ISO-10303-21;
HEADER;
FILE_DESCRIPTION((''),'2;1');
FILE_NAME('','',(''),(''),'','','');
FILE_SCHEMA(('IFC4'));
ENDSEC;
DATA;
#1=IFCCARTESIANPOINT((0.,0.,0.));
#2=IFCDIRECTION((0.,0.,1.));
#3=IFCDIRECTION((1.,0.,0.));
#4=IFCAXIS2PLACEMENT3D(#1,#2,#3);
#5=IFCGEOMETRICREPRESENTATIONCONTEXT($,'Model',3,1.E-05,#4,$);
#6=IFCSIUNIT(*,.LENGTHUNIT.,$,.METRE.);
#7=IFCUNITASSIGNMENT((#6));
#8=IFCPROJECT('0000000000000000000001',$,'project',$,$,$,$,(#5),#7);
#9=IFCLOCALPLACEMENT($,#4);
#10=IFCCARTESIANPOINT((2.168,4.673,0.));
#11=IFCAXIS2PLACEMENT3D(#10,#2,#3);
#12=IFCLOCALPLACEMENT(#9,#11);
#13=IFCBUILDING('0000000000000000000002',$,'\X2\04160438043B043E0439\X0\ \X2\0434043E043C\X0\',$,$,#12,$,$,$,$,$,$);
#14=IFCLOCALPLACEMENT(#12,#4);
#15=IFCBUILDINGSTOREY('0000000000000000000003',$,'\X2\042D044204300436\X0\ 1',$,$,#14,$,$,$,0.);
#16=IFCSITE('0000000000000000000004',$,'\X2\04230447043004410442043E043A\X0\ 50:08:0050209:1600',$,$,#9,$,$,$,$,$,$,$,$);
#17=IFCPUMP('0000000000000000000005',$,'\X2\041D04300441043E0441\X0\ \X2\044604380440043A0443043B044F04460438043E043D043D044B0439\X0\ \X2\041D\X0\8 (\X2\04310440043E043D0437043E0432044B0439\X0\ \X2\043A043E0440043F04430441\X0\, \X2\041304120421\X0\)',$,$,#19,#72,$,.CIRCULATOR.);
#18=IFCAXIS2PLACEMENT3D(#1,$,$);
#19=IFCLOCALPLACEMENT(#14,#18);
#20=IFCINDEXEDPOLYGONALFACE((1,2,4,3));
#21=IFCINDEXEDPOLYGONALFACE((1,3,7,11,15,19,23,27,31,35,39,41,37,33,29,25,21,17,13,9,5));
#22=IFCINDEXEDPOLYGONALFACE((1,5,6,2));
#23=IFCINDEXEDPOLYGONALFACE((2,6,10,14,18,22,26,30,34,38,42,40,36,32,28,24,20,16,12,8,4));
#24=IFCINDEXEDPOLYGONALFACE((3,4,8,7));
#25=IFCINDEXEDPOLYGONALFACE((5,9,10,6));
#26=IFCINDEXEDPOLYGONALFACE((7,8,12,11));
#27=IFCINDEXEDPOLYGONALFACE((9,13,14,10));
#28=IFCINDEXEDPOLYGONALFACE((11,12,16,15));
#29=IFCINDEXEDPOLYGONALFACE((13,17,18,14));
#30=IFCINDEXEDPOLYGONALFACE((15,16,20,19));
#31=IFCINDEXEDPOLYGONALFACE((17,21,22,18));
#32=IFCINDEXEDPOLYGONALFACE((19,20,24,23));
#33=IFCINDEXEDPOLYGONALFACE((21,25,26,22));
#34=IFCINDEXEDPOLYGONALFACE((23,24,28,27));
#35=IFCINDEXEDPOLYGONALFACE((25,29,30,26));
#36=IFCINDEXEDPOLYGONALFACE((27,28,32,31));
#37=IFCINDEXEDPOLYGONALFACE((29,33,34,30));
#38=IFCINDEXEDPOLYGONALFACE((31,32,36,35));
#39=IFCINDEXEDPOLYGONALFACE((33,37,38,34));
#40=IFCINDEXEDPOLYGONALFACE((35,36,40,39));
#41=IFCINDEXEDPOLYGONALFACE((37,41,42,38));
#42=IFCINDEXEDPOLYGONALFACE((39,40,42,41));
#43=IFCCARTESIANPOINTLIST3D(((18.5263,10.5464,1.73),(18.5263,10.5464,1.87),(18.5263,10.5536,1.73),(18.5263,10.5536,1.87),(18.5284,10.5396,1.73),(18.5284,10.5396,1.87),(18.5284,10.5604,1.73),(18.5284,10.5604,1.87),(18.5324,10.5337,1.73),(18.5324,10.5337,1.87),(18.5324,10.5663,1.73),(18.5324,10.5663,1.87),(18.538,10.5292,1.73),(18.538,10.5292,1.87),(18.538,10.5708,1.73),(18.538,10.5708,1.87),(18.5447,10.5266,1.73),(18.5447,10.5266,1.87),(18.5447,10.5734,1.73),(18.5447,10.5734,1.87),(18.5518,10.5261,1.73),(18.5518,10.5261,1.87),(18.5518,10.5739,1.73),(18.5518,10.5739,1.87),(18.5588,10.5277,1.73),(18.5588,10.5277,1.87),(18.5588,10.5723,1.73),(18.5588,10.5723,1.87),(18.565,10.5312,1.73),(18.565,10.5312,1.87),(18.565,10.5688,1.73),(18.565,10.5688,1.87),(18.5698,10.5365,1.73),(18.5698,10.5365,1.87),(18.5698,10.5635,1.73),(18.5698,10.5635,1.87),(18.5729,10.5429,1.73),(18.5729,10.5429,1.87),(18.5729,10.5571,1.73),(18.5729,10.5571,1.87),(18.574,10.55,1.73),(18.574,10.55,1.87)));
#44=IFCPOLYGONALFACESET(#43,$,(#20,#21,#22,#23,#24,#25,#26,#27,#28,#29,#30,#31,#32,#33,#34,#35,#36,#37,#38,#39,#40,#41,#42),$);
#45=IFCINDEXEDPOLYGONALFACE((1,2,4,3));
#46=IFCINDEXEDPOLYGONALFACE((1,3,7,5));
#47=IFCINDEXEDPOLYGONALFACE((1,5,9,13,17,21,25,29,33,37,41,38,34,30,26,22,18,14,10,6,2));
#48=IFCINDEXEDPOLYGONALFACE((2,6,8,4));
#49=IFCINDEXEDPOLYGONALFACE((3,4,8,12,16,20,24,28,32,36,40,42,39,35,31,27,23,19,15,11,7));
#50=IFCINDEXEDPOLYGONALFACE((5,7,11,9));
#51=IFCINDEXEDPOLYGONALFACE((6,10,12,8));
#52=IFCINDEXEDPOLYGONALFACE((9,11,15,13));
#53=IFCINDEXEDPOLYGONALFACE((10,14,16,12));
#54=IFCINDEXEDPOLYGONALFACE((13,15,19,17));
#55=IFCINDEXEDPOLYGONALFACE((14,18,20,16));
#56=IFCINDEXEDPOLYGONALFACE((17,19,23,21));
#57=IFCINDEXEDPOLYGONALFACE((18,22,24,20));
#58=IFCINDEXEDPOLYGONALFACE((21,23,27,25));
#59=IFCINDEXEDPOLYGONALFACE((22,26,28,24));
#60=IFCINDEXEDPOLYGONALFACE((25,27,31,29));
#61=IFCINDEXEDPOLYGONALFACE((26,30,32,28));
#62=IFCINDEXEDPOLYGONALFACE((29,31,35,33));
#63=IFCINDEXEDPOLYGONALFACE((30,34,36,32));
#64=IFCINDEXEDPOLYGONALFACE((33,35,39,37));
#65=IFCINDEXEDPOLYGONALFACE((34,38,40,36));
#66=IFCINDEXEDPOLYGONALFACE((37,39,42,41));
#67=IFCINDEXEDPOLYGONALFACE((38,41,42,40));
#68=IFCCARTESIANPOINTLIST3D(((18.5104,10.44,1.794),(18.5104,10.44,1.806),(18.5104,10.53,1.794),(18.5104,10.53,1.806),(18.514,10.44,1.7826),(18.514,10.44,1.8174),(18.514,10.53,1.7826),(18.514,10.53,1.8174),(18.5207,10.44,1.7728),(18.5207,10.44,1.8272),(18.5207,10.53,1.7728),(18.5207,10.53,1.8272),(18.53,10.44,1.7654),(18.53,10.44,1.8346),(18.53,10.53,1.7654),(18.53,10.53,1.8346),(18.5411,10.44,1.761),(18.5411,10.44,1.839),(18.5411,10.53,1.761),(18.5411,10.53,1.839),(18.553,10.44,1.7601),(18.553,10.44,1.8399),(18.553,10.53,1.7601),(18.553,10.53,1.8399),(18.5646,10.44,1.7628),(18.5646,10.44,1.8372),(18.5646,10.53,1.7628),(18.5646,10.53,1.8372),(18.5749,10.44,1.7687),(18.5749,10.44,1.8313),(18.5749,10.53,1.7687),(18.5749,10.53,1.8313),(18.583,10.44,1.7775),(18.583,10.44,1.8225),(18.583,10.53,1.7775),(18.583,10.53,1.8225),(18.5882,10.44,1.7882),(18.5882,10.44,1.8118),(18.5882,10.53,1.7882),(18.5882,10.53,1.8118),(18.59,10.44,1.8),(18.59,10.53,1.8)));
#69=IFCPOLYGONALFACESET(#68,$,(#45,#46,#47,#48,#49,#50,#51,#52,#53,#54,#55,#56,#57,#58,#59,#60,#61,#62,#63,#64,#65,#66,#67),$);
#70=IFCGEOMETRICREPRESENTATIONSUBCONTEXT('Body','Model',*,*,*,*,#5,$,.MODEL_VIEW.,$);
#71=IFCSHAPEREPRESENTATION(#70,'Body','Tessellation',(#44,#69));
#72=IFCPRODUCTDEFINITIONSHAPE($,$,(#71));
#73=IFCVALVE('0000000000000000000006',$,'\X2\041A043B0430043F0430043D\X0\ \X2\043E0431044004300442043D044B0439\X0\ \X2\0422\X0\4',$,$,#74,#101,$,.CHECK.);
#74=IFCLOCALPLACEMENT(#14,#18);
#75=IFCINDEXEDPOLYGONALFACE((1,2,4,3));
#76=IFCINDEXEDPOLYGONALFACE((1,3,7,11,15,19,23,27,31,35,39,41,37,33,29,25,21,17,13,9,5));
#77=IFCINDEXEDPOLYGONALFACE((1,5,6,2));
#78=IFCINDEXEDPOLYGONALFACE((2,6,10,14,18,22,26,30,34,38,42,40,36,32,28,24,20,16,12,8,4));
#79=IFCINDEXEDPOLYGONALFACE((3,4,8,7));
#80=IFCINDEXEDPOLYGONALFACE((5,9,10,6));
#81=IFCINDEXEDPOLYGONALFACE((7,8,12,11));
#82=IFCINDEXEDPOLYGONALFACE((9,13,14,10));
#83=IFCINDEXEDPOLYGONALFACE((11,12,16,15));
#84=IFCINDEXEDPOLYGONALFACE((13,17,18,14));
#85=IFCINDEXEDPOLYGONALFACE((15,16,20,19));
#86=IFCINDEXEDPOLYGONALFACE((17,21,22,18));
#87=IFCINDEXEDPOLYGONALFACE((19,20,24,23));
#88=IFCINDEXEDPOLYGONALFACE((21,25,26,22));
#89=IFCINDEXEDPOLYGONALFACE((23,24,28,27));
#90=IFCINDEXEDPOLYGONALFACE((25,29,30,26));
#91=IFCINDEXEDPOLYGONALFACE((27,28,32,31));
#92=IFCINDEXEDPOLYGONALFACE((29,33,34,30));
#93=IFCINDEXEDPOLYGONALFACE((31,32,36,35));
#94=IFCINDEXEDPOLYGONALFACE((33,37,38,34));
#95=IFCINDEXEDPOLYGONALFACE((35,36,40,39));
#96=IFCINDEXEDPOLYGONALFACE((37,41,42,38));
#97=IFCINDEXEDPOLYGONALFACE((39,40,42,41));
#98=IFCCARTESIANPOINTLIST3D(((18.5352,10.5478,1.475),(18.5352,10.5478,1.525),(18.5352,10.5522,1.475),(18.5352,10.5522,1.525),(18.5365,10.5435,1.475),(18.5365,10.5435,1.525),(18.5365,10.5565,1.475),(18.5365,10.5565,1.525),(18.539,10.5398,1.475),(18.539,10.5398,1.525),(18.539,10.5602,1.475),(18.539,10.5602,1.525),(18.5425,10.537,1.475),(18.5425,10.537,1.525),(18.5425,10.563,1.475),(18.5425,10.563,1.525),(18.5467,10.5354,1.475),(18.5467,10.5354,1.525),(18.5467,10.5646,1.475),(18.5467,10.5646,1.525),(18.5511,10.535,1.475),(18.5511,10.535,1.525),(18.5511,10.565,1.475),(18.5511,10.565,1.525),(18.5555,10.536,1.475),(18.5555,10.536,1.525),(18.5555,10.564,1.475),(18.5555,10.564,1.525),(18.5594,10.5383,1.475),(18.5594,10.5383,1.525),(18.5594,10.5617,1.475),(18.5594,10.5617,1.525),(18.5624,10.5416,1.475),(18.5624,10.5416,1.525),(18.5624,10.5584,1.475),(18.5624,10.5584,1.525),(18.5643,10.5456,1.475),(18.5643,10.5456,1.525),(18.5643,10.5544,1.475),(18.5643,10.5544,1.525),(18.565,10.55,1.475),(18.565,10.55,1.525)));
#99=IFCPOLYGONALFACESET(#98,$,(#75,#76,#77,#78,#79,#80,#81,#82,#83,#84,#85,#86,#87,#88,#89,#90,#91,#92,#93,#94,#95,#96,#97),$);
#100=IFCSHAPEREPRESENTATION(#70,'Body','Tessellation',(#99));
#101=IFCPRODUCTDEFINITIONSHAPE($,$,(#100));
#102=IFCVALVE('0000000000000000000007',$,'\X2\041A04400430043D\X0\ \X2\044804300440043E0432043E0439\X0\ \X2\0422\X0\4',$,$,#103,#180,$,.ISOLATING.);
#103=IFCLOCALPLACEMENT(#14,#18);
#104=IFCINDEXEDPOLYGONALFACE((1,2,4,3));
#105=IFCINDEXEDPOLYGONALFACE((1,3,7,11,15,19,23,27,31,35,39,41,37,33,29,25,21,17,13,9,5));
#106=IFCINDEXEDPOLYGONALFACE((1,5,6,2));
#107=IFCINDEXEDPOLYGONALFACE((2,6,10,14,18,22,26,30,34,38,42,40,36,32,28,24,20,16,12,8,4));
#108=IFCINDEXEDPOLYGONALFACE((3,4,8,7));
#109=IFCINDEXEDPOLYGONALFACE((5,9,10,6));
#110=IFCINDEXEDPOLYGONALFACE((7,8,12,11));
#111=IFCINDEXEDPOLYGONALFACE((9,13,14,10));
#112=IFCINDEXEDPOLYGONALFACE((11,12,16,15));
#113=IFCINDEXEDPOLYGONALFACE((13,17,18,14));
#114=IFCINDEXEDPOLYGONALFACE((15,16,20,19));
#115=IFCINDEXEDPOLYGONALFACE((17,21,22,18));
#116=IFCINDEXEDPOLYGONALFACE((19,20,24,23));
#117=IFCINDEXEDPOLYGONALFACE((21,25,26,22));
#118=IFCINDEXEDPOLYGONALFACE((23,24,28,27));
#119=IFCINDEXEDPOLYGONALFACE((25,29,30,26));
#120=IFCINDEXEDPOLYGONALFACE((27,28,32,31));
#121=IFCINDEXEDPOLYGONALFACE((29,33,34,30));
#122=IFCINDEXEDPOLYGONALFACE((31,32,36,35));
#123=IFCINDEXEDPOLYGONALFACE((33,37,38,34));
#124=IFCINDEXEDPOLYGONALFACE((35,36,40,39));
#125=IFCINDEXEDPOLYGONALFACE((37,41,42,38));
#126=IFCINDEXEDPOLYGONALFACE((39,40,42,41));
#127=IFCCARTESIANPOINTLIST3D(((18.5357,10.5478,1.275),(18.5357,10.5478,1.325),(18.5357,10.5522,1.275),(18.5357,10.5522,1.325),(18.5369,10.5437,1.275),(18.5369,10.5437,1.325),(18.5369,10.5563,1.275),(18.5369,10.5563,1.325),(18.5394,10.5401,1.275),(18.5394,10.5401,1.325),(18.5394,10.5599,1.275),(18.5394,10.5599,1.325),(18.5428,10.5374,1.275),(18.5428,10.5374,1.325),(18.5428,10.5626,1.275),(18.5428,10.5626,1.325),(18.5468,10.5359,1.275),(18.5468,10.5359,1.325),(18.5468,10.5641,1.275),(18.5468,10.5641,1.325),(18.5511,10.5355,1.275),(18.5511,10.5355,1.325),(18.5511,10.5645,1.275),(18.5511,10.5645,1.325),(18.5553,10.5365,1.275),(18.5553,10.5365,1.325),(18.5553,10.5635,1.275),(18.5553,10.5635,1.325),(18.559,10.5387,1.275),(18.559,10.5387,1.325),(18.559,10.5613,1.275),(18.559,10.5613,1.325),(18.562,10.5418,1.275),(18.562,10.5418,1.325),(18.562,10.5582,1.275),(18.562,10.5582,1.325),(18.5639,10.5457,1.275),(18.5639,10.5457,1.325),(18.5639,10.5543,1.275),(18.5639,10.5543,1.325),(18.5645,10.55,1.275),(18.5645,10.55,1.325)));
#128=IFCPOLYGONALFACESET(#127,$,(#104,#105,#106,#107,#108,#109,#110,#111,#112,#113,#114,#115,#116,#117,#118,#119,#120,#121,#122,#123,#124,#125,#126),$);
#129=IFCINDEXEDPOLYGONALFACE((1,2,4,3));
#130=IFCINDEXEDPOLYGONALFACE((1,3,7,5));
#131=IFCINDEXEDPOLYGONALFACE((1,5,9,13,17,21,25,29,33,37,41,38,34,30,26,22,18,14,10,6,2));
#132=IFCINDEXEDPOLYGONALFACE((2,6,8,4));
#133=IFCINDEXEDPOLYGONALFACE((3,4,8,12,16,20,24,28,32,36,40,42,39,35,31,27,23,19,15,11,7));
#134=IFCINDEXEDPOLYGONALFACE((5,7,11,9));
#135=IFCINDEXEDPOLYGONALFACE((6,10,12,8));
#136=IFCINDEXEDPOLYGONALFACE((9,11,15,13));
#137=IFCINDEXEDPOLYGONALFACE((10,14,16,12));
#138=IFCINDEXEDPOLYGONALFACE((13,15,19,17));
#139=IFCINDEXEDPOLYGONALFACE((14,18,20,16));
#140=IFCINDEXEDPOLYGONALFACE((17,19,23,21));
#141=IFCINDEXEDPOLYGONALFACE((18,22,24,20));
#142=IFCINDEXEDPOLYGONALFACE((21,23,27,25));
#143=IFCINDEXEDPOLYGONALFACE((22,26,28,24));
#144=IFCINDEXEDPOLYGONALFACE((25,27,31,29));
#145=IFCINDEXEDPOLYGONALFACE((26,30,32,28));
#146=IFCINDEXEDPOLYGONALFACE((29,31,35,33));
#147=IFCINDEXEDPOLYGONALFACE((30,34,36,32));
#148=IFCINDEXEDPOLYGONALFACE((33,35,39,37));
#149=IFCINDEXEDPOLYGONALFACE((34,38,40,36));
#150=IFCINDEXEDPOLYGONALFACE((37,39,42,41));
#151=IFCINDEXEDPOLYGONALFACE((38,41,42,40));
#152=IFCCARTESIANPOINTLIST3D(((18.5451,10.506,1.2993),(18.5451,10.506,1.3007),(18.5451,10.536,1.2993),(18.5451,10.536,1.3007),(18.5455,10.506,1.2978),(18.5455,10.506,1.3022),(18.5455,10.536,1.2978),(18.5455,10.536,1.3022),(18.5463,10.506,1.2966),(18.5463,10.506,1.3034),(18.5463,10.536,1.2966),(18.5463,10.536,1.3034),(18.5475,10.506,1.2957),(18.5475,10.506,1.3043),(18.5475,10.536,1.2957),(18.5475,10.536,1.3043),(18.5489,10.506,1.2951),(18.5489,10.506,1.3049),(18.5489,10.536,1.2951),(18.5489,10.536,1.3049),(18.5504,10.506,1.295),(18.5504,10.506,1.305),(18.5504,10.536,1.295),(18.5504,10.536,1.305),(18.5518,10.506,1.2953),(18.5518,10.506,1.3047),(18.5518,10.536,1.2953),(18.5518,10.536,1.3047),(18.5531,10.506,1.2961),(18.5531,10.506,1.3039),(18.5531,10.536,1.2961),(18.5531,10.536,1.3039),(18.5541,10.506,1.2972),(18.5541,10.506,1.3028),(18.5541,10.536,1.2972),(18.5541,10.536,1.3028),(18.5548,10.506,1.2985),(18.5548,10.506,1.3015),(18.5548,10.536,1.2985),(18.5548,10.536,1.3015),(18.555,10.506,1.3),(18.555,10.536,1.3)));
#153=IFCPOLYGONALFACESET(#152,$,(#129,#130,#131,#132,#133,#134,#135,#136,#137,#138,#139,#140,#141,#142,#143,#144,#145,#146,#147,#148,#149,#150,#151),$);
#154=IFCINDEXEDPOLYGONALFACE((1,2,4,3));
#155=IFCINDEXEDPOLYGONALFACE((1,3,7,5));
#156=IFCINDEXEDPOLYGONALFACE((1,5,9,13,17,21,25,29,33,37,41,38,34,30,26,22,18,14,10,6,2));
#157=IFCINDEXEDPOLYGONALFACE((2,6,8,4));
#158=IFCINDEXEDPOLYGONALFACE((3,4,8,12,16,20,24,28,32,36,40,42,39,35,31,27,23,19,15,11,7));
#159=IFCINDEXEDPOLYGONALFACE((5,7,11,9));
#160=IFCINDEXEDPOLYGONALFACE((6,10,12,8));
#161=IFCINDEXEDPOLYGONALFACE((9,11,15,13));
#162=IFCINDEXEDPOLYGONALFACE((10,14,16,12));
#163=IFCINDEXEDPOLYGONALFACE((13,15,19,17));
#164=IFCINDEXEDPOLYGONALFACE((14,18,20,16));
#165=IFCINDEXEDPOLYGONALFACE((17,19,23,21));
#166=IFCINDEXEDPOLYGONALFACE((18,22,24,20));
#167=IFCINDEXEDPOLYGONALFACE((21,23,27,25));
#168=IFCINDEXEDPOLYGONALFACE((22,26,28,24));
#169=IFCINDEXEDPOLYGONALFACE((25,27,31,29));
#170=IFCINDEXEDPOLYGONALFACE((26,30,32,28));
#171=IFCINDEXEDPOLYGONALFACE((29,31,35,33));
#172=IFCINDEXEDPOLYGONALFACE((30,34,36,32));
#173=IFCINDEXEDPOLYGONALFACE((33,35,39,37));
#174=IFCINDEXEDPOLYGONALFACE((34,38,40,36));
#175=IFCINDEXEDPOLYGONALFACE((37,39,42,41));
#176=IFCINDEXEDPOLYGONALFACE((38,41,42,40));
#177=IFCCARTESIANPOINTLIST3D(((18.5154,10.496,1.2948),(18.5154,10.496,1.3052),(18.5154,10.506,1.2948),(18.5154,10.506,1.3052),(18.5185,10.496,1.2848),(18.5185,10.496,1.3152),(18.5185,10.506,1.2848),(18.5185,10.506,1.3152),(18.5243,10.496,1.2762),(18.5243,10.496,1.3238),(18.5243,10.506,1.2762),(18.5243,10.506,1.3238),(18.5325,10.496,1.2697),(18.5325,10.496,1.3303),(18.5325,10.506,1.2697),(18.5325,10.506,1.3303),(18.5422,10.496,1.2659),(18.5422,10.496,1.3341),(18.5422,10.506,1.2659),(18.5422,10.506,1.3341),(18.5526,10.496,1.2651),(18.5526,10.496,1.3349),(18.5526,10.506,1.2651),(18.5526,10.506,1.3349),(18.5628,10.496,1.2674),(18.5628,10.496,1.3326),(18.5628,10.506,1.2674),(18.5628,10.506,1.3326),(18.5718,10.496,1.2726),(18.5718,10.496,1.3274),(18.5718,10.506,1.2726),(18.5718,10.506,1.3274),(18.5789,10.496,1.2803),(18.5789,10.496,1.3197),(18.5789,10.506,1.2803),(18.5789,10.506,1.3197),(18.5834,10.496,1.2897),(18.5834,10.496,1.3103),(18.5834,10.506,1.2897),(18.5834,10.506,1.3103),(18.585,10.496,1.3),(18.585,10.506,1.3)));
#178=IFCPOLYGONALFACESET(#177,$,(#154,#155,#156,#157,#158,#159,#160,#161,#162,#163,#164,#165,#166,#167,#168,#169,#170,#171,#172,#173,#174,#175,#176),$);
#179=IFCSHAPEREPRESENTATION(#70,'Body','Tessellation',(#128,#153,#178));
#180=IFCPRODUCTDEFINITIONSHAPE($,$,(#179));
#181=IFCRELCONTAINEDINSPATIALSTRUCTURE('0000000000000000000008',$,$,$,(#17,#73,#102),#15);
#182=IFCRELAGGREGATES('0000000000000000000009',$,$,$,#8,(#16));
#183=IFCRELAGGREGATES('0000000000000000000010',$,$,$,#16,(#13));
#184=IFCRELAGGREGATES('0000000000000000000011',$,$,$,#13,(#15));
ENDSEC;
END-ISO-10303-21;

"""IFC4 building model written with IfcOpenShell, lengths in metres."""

from ifc_helpers import new_model, si_unit, frame, origin_with_axes, origin_2d, place, context, subcontext, project, spatial, circle, extrude, element, save


model = new_model("IFC4")

# Units and contexts
model_context = context("Model", 3, precision=1e-05, world=origin_with_axes())
body_context = subcontext(model_context, "Body", "Model", "MODEL_VIEW")
ifc_project = project(units=[si_unit("LENGTHUNIT", "METRE")], contexts=[model_context])

# Site, building, storey
site_placement = place(None, origin_with_axes())
site = spatial("IfcSite", under=ifc_project, at=site_placement, Name="Участок 50:08:0050209:1600")
building_placement = place(site_placement, frame((2.168, 4.673, 0.0), z_axis=(0.0, 0.0, 1.0), x_axis=(1.0, 0.0, 0.0)))
building = spatial("IfcBuilding", under=site, at=building_placement, Name="Жилой дом")
storey_placement = place(building_placement, origin_with_axes())
storey = spatial("IfcBuildingStorey", under=building, at=storey_placement, Name="Этаж 1", Elevation=0.0)

# Pump
pump_placement = place(storey_placement, origin_with_axes())
element("IfcPump", 1, at=pump_placement, inside=storey, Name="Насос циркуляционный Н8 (бронзовый корпус, ГВС)", PredefinedType="CIRCULATOR", context=body_context, shape_type="SweptSolid", body=[
    extrude(circle(Radius=0.024, at=origin_2d()), frame((18.55, 10.55, 1.73), z_axis=(0.0, 0.0, 1.0), x_axis=(1.0, 0.0, 0.0)), (0.0, 0.0, 1.0), 0.14),
    extrude(circle(Radius=0.04, at=origin_2d()), frame((18.55, 10.53, 1.8), z_axis=(0.0, -1.0, 0.0), x_axis=(1.0, 0.0, 0.0)), (0.0, 0.0, 1.0), 0.09),
])

# Valves
valve_1_placement = place(storey_placement, origin_with_axes())
element("IfcValve", 2, at=valve_1_placement, inside=storey, Name="Клапан обратный Т4", PredefinedType="CHECK", context=body_context, shape_type="SweptSolid", body=[
    extrude(circle(Radius=0.015, at=origin_2d()), frame((18.55, 10.55, 1.475), z_axis=(0.0, 0.0, 1.0), x_axis=(1.0, 0.0, 0.0)), (0.0, 0.0, 1.0), 0.05),
])
valve_2_placement = place(storey_placement, origin_with_axes())
element("IfcValve", 3, at=valve_2_placement, inside=storey, Name="Кран шаровой Т4", PredefinedType="ISOLATING", context=body_context, shape_type="SweptSolid", body=[
    extrude(circle(Radius=0.0145, at=origin_2d()), frame((18.55, 10.55, 1.275), z_axis=(0.0, 0.0, 1.0), x_axis=(1.0, 0.0, 0.0)), (0.0, 0.0, 1.0), 0.05),
    extrude(circle(Radius=0.005, at=origin_2d()), frame((18.55, 10.536, 1.3), z_axis=(0.0, -1.0, 0.0), x_axis=(1.0, 0.0, 0.0)), (0.0, 0.0, 1.0), 0.03),
    extrude(circle(Radius=0.035, at=origin_2d()), frame((18.55, 10.506, 1.3), z_axis=(0.0, -1.0, 0.0), x_axis=(1.0, 0.0, 0.0)), (0.0, 0.0, 1.0), 0.01),
])

save(model, "model.ifc")
